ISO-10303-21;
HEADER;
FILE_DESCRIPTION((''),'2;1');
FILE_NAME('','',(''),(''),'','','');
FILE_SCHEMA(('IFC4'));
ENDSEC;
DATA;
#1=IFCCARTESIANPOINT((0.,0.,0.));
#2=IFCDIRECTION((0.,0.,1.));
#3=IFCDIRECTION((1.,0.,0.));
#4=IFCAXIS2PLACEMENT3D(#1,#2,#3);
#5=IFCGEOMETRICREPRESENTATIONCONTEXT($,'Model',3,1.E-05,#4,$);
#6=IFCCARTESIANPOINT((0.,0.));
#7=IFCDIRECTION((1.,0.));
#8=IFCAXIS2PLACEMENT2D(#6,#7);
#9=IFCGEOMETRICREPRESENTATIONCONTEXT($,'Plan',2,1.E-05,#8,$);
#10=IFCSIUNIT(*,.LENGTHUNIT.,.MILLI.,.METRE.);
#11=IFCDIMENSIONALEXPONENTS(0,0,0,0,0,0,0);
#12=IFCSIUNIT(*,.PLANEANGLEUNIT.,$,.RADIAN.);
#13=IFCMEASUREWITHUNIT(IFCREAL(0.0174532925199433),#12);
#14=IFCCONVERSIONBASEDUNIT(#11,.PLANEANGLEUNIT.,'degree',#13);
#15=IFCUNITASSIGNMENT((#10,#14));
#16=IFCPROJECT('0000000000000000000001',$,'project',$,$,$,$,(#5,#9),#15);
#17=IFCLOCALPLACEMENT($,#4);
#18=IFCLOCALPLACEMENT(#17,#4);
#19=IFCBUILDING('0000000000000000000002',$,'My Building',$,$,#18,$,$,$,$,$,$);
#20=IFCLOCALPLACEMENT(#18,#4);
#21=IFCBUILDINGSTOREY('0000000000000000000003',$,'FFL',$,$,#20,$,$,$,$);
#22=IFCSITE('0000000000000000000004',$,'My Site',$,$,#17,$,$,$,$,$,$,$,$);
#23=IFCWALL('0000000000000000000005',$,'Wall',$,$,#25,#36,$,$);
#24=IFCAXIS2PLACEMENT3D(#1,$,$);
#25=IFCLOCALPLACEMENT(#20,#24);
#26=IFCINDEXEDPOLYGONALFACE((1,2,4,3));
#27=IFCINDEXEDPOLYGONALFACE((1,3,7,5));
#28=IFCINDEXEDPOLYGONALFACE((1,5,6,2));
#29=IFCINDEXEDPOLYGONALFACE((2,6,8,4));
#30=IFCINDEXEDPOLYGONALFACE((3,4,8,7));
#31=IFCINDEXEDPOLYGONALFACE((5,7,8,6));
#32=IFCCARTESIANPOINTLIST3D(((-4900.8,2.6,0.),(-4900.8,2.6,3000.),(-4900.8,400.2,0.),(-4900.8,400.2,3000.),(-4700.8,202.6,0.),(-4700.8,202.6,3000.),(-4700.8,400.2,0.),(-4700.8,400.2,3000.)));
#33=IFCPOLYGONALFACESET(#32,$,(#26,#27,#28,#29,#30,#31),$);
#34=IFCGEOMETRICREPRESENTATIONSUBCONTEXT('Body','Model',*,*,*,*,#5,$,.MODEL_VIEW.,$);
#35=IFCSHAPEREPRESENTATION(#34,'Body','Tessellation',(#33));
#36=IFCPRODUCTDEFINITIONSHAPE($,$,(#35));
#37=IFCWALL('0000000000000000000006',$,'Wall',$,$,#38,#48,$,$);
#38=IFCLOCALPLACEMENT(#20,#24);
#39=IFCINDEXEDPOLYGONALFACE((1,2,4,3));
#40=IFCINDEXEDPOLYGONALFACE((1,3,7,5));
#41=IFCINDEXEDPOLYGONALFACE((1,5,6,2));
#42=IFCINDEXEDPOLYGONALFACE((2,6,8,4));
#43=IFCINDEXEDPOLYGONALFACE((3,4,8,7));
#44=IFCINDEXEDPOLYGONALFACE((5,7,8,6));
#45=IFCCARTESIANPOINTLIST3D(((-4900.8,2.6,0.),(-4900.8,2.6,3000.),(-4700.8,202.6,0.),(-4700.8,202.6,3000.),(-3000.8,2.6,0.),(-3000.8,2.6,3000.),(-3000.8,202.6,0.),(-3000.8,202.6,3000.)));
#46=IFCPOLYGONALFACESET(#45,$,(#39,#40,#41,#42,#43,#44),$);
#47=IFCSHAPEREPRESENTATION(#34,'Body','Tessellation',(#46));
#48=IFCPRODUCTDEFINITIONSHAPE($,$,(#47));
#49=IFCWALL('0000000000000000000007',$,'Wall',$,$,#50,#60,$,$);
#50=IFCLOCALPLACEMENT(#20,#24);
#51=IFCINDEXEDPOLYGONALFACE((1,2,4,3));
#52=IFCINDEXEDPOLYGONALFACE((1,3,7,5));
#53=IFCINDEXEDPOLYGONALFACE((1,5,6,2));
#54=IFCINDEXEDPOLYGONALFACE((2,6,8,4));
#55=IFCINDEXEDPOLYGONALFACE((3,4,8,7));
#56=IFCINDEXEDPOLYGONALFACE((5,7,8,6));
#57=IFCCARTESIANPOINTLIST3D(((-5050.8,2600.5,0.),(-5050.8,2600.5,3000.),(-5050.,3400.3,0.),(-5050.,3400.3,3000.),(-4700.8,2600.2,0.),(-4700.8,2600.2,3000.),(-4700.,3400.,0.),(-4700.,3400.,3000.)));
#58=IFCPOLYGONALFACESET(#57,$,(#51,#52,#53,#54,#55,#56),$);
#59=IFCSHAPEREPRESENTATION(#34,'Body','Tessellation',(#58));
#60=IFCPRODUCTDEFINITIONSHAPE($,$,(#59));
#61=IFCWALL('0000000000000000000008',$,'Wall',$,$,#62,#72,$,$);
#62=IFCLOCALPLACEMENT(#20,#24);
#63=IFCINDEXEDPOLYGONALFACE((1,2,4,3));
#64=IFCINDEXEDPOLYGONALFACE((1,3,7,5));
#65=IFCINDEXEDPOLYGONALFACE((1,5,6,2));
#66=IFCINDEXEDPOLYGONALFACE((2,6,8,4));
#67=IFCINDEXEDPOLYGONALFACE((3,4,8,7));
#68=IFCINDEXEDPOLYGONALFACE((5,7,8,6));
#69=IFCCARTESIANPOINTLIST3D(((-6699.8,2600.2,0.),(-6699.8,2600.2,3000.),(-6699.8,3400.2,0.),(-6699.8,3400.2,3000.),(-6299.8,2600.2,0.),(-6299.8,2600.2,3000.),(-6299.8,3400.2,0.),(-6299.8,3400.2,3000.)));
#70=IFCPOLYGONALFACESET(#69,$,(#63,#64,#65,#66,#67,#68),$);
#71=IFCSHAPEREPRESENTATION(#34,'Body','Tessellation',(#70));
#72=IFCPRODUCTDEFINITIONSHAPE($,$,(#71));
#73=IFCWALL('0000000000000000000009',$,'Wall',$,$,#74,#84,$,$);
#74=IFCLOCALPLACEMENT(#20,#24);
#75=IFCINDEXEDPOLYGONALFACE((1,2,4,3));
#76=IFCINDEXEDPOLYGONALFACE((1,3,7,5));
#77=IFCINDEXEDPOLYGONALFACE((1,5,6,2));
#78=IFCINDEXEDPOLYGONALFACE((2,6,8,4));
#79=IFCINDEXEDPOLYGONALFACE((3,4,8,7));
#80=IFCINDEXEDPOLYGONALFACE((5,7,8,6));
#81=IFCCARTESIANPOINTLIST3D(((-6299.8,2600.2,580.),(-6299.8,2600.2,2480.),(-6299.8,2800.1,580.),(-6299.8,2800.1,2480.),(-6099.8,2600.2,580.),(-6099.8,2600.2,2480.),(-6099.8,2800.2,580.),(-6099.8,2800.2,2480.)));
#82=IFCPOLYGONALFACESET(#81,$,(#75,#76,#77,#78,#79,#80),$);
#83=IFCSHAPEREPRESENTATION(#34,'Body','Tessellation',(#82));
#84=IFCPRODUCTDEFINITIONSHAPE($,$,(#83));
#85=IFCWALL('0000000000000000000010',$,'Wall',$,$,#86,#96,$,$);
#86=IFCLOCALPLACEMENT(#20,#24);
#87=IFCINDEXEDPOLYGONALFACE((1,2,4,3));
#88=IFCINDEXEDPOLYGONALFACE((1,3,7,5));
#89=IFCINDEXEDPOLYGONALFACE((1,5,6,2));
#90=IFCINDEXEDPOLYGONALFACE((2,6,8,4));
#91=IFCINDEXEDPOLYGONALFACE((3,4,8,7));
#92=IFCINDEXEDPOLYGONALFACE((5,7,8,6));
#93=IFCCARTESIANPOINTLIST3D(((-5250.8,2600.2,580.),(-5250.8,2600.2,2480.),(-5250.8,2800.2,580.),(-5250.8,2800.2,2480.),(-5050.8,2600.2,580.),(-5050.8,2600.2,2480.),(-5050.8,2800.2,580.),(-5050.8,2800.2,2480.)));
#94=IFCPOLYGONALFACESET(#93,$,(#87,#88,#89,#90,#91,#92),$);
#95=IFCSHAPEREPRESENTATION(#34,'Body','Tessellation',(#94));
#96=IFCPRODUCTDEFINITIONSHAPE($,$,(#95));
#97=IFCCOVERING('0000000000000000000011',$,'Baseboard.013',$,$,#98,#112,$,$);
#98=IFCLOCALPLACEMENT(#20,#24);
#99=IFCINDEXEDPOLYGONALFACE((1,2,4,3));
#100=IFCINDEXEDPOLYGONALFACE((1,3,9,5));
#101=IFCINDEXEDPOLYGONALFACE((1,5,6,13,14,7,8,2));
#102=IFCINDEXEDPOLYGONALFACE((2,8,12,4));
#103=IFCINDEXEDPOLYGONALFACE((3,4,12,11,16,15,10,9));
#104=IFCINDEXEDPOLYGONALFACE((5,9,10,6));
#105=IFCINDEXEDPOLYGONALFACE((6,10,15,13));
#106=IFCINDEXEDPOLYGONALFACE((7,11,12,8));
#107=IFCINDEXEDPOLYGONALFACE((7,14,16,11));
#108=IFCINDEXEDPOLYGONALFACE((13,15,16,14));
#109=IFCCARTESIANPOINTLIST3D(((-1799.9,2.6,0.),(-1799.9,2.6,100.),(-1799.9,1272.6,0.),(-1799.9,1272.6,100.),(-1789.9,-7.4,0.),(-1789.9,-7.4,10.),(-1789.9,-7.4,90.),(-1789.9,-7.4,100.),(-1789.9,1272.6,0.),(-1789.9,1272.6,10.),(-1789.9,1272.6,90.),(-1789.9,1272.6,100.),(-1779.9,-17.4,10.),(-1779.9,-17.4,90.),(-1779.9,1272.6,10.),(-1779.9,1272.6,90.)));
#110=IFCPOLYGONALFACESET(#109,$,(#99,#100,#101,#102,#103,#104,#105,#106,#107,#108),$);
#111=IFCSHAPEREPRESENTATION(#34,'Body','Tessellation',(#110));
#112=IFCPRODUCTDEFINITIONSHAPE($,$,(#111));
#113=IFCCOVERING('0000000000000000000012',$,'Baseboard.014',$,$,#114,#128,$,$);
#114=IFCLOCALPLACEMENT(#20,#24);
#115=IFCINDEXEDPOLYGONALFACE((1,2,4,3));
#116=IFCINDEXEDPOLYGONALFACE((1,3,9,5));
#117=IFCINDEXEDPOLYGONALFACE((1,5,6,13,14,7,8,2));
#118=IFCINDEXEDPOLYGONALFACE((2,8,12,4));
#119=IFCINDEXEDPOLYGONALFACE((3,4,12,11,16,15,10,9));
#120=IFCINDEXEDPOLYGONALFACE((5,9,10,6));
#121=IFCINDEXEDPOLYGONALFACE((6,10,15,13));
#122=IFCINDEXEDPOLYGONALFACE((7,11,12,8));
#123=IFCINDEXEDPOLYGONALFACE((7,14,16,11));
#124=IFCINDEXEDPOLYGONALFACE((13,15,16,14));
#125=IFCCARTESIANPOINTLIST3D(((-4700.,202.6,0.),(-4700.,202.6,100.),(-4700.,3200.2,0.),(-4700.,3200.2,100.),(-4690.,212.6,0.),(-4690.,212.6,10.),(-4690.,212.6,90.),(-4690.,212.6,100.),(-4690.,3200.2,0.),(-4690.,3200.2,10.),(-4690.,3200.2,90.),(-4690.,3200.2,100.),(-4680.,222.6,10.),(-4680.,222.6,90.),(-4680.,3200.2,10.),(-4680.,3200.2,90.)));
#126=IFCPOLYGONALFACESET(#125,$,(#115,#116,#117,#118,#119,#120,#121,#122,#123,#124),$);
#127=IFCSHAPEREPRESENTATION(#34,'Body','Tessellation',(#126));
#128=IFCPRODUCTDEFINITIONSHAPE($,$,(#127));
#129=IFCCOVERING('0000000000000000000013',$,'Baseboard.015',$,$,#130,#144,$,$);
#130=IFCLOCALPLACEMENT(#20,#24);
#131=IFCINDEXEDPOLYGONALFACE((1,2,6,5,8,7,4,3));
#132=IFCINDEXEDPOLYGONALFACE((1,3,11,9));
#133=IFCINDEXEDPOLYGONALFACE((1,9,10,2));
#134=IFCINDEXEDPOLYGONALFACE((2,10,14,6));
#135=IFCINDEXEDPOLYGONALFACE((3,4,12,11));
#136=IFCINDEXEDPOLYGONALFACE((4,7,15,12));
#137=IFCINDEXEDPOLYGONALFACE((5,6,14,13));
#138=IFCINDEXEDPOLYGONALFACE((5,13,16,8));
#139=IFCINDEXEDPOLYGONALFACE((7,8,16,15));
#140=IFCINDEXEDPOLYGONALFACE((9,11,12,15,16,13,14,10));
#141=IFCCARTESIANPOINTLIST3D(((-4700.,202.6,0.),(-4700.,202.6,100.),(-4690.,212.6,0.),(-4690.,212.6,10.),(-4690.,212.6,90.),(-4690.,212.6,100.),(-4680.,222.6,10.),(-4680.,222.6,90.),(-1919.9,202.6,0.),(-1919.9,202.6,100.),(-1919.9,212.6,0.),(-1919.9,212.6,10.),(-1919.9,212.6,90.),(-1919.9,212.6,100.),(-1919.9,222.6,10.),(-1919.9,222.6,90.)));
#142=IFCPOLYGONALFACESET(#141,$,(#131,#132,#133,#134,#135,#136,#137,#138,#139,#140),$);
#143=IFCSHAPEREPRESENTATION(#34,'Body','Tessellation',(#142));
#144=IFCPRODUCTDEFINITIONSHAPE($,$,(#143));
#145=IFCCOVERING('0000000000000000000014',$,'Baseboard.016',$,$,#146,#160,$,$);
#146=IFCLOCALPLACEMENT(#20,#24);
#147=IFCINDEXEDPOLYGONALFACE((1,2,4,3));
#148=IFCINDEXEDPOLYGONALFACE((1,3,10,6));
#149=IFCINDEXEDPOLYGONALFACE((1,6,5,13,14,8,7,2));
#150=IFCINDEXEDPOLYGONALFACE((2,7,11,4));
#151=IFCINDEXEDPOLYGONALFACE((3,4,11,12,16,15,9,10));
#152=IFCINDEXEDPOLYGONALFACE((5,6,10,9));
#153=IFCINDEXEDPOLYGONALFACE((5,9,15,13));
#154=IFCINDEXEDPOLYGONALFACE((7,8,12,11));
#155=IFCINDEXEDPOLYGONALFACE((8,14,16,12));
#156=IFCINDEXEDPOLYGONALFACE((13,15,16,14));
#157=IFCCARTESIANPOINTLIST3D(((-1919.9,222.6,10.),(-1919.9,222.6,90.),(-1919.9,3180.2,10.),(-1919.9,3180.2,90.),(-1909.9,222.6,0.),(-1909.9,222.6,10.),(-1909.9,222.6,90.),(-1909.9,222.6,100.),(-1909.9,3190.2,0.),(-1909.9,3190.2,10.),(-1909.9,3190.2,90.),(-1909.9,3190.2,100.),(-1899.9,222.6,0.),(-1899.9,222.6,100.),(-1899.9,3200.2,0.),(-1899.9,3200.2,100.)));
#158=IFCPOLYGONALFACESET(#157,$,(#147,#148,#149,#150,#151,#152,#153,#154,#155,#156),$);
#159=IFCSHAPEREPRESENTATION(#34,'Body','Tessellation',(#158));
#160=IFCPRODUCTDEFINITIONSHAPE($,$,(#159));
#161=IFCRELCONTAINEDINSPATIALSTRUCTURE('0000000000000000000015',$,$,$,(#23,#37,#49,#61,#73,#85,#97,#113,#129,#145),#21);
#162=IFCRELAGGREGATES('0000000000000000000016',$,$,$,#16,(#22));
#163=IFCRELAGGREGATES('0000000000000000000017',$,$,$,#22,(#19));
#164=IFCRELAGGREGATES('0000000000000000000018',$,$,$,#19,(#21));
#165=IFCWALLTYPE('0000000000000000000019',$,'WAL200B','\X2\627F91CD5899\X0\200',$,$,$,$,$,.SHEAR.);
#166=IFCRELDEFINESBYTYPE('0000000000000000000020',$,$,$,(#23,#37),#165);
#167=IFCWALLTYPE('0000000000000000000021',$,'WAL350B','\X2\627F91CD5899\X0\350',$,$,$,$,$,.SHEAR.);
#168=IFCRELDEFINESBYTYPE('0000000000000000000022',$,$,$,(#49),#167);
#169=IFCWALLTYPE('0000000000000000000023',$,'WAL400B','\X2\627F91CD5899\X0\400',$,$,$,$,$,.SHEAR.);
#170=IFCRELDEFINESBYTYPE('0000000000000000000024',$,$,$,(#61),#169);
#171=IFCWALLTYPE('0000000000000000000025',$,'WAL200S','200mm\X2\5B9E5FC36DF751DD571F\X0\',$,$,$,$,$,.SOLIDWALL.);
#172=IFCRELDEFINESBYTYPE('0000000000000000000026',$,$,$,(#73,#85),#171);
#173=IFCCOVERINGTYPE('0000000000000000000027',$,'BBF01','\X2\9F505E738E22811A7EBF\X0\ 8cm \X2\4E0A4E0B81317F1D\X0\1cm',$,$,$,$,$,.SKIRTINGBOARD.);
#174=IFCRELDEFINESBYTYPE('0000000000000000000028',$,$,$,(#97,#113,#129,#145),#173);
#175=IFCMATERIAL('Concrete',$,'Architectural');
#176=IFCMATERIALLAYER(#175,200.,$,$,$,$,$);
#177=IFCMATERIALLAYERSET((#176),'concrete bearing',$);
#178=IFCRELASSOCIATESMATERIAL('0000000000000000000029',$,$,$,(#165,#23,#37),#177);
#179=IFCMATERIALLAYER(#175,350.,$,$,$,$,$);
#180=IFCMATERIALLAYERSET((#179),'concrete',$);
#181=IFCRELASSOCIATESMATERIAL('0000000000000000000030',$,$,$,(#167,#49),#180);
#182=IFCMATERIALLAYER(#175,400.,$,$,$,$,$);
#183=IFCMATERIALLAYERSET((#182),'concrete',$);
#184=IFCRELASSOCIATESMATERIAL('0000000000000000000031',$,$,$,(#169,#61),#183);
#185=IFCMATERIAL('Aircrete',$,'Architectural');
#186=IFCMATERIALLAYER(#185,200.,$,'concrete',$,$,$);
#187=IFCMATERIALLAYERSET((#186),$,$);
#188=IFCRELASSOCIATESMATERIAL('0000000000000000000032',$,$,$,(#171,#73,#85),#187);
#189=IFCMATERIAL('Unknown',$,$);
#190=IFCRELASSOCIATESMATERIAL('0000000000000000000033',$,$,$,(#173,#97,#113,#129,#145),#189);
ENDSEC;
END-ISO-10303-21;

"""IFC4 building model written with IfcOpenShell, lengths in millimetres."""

from ifc_helpers import new_model, entity, si_unit, converted_unit, frame, origin_with_axes, origin_2d_with_axis, place, context, subcontext, project, spatial, line, indexed_curve, outline, extrude, clip, halfspace, material, layer, layer_set, layer_usage, material_profile, profile_set, profile_usage, type_object, element, save


model = new_model("IFC4")

# Units and contexts
model_context = context("Model", 3, precision=1e-05, world=origin_with_axes())
plan_context = context("Plan", 2, precision=1e-05, world=origin_2d_with_axis())
body_context_1 = subcontext(model_context, "Body", "Model", "MODEL_VIEW")
ifc_project = project(units=[si_unit("LENGTHUNIT", "METRE", prefix="MILLI"), converted_unit("PLANEANGLEUNIT", "degree", entity("IfcReal", 0.0174532925199433), si_unit("PLANEANGLEUNIT", "RADIAN"), dimensions=[0, 0, 0, 0, 0, 0, 0])], contexts=[model_context, plan_context])

# Site, building, storey
site_placement = place(None, origin_with_axes())
site = spatial("IfcSite", under=ifc_project, at=site_placement, Name="My Site")
building_placement = place(site_placement, origin_with_axes())
building = spatial("IfcBuilding", under=site, at=building_placement, Name="My Building")
storey_placement = place(building_placement, origin_with_axes())
storey = spatial("IfcBuildingStorey", under=building, at=storey_placement, Name="FFL")

# Shared definitions
ifc_material_1 = material(Name="Aircrete", Category="Architectural")

# Walls
ifc_material_2 = material(Name="Concrete", Category="Architectural")
ifc_layer_1 = layer(ifc_material_2, 200.0)
ifc_layer_set_1 = layer_set([ifc_layer_1], Name="concrete bearing")
ifc_layer_usage_1 = layer_usage(ifc_layer_set_1, "AXIS2", "NEGATIVE", 0.0)
wall_type_1 = type_object("IfcWallType", Name="WAL200B", Description="承重墙200", PredefinedType="SHEAR", material=ifc_layer_set_1)
wall_1_placement = place(storey_placement, frame((-4700.8, 400.2, 0.0), z_axis=(0.0, 0.0, 1.0), x_axis=(0.0, -1.0, 0.0)))
element("IfcWall", 1, at=wall_1_placement, inside=storey, type_object=wall_type_1, material=ifc_layer_usage_1, Name="Wall", context=body_context_1, shape_type="SweptSolid", body=[
    extrude(outline(indexed_curve([(0.0, -200.0), (0.0, 0.0), (197.6, 0.0), (397.6, -200.0)], segments=[line(1, 2, 3, 4, 1)])), origin_with_axes(), (0.0, 0.0, 1.0), 3000.0),
])
ifc_layer_usage_2 = layer_usage(ifc_layer_set_1, "AXIS2", "NEGATIVE", 0.0)
wall_2_placement = place(storey_placement, frame((-4700.8, 202.6, 0.0), z_axis=(0.0, 0.0, 1.0), x_axis=(1.0, 0.000001, 0.0)))
element("IfcWall", 2, at=wall_2_placement, inside=storey, type_object=wall_type_1, material=ifc_layer_usage_2, Name="Wall", context=body_context_1, shape_type="SweptSolid", body=[
    extrude(outline(indexed_curve([(-200.0, -200.0), (0.0, 0.0), (1700.0, 0.0), (1700.0, -200.0)], segments=[line(1, 2, 3, 4, 1)])), origin_with_axes(), (0.0, 0.0, 1.0), 3000.0),
])
ifc_layer_2 = layer(ifc_material_2, 350.0)
ifc_layer_set_2 = layer_set([ifc_layer_2], Name="concrete")
ifc_layer_usage_3 = layer_usage(ifc_layer_set_2, "AXIS2", "POSITIVE", 0.0)
wall_type_2 = type_object("IfcWallType", Name="WAL350B", Description="承重墙350", PredefinedType="SHEAR", material=ifc_layer_set_2)
wall_3_placement = place(storey_placement, frame((-4700.8, 2600.2, 0.0), z_axis=(0.0, 0.0, 1.0), x_axis=(0.000938, 1.0, 0.0)))
element("IfcWall", 3, at=wall_3_placement, inside=storey, type_object=wall_type_2, material=ifc_layer_usage_3, Name="Wall", context=body_context_1, shape_type="SweptSolid", body=[
    extrude(outline(indexed_curve([(0.0, 0.0), (0.0, 350.0), (799.8, 350.0), (799.8, 0.0)], segments=[line(1, 2, 3, 4, 1)])), origin_with_axes(), (0.0, 0.0, 1.0), 3000.0),
])
ifc_layer_3 = layer(ifc_material_2, 400.0)
ifc_layer_set_3 = layer_set([ifc_layer_3], Name="concrete")
ifc_layer_usage_4 = layer_usage(ifc_layer_set_3, "AXIS2", "POSITIVE", 0.0)
wall_type_3 = type_object("IfcWallType", Name="WAL400B", Description="承重墙400", PredefinedType="SHEAR", material=ifc_layer_set_3)
wall_4_placement = place(storey_placement, frame((-6699.8, 3400.2, 0.0), z_axis=(0.0, 0.0, 1.0), x_axis=(0.0, -1.0, 0.0)))
element("IfcWall", 4, at=wall_4_placement, inside=storey, type_object=wall_type_3, material=ifc_layer_usage_4, Name="Wall", context=body_context_1, shape_type="SweptSolid", body=[
    extrude(outline(indexed_curve([(0.0, 0.0), (0.0, 400.0), (800.0, 400.0), (800.0, 0.0)], segments=[line(1, 2, 3, 4, 1)])), origin_with_axes(), (0.0, 0.0, 1.0), 3000.0),
])
ifc_layer_4 = layer(ifc_material_1, 200.0, Name="concrete")
ifc_layer_set_4 = layer_set([ifc_layer_4])
ifc_layer_usage_5 = layer_usage(ifc_layer_set_4, "AXIS2", "NEGATIVE", 0.0)
wall_type_4 = type_object("IfcWallType", Name="WAL200S", Description="200mm实心混凝土", PredefinedType="SOLIDWALL", material=ifc_layer_set_4)
wall_5_placement = place(storey_placement, frame((-6299.8, 2600.2, 580.0), z_axis=(0.0, 0.0, 1.0), x_axis=(-0.000002, 1.0, 0.0)))
element("IfcWall", 5, at=wall_5_placement, inside=storey, type_object=wall_type_4, material=ifc_layer_usage_5, Name="Wall", context=body_context_1, shape_type="SweptSolid", body=[
    extrude(outline(indexed_curve([(0.0, -200.0), (0.0, 0.0), (200.0, 0.0), (200.0, -200.0)], segments=[line(1, 2, 3, 4, 1)])), origin_with_axes(), (0.0, 0.0, 1.0), 1900.0),
])
ifc_layer_usage_6 = layer_usage(ifc_layer_set_4, "AXIS2", "NEGATIVE", 0.0)
wall_6_placement = place(storey_placement, frame((-5050.8, 2800.2, 580.0), z_axis=(0.0, 0.0, 1.0), x_axis=(0.000002, -1.0, 0.0)))
element("IfcWall", 6, at=wall_6_placement, inside=storey, type_object=wall_type_4, material=ifc_layer_usage_6, Name="Wall", context=body_context_1, shape_type="SweptSolid", body=[
    extrude(outline(indexed_curve([(0.0, -200.0), (0.0, 0.0), (200.0, 0.0), (200.0, -200.0)], segments=[line(1, 2, 3, 4, 1)])), origin_with_axes(), (0.0, 0.0, 1.0), 1900.0),
])

# Coverings
ifc_material_3 = material(Name="Unknown")
ifc_material_profile_1 = material_profile(ifc_material_3, outline(indexed_curve([(0.0, 100.0), (10.0, 100.0), (10.0, 90.0), (20.0, 90.0), (20.0, 10.0), (10.0, 10.0), (10.0, 0.0), (0.0, 0.0), (0.0, 100.0)])))
ifc_profile_set_1 = profile_set([ifc_material_profile_1])
ifc_profile_usage_1 = profile_usage(ifc_profile_set_1, cardinal=5)
covering_type = type_object("IfcCoveringType", Name="BBF01", Description="齐平踢脚线 8cm 上下脱缝1cm", PredefinedType="SKIRTINGBOARD", material=ifc_profile_set_1)
covering_1_placement = place(storey_placement, frame((-1799.9, 1272.6, 0.0), z_axis=(-0.000001, -1.0, 0.0), x_axis=(1.0, -0.000001, 0.0)))
element("IfcCovering", 7, at=covering_1_placement, inside=storey, type_object=covering_type, material=ifc_profile_usage_1, Name="Baseboard.013", context=body_context_1, shape_type="Clipping", body=[
    clip(extrude(outline(indexed_curve([(0.0, 100.0), (10.0, 100.0), (10.0, 90.0), (20.0, 90.0), (20.0, 10.0), (10.0, 10.0), (10.0, 0.0), (0.0, 0.0), (0.0, 100.0)])), origin_with_axes(), (0.0, 0.0, 1.0), 1290.0), halfspace(frame((20.0, 0.0, 1290.0), z_axis=(-0.707107, 0.0, 0.707107), x_axis=(0.0, 1.0, 0.0)), False)),
])
ifc_profile_usage_2 = profile_usage(ifc_profile_set_1, cardinal=5)
covering_2_placement = place(storey_placement, frame((-4700.0, 3200.2, 0.0), z_axis=(-0.000001, -1.0, 0.0), x_axis=(1.0, -0.000001, 0.0)))
element("IfcCovering", 8, at=covering_2_placement, inside=storey, type_object=covering_type, material=ifc_profile_usage_2, Name="Baseboard.014", context=body_context_1, shape_type="Clipping", body=[
    clip(extrude(outline(indexed_curve([(0.0, 100.0), (10.0, 100.0), (10.0, 90.0), (20.0, 90.0), (20.0, 10.0), (10.0, 10.0), (10.0, 0.0), (0.0, 0.0), (0.0, 100.0)])), origin_with_axes(), (0.0, 0.0, 1.0), 2997.6), halfspace(frame((0.0, 0.0, 2997.6), z_axis=(0.707107, 0.0, 0.707106), x_axis=(0.0, -1.0, 0.0)), False)),
])
ifc_profile_usage_3 = profile_usage(ifc_profile_set_1, cardinal=5)
covering_3_placement = place(storey_placement, frame((-4700.0, 202.6, 0.0), z_axis=(1.0, -0.000001, 0.0), x_axis=(0.000001, 1.0, 0.0)))
element("IfcCovering", 9, at=covering_3_placement, inside=storey, type_object=covering_type, material=ifc_profile_usage_3, Name="Baseboard.015", context=body_context_1, shape_type="Clipping", body=[
    clip(extrude(outline(indexed_curve([(0.0, 100.0), (10.0, 100.0), (10.0, 90.0), (20.0, 90.0), (20.0, 10.0), (10.0, 10.0), (10.0, 0.0), (0.0, 0.0), (0.0, 100.0)])), origin_with_axes(), (0.0, 0.0, 1.0), 2780.1), halfspace(frame((0.0, 0.0, 0.0), z_axis=(0.707106, 0.0, -0.707107), x_axis=(0.0, -1.0, 0.0)), False)),
])
ifc_profile_usage_4 = profile_usage(ifc_profile_set_1, cardinal=5)
covering_4_placement = place(storey_placement, frame((-1899.9, 222.6, 0.0), z_axis=(0.000001, 1.0, 0.0), x_axis=(-1.0, 0.000001, 0.0)))
element("IfcCovering", 10, at=covering_4_placement, inside=storey, type_object=covering_type, material=ifc_profile_usage_4, Name="Baseboard.016", context=body_context_1, shape_type="Clipping", body=[
    clip(extrude(outline(indexed_curve([(0.0, 100.0), (10.0, 100.0), (10.0, 90.0), (20.0, 90.0), (20.0, 10.0), (10.0, 10.0), (10.0, 0.0), (0.0, 0.0), (0.0, 100.0)])), origin_with_axes(), (0.0, 0.0, 1.0), 2977.6), halfspace(frame((0.0, 0.0, 2977.6), z_axis=(0.707107, 0.0, 0.707106), x_axis=(0.0, -1.0, 0.0)), False)),
])

save(model, "model.ifc")
